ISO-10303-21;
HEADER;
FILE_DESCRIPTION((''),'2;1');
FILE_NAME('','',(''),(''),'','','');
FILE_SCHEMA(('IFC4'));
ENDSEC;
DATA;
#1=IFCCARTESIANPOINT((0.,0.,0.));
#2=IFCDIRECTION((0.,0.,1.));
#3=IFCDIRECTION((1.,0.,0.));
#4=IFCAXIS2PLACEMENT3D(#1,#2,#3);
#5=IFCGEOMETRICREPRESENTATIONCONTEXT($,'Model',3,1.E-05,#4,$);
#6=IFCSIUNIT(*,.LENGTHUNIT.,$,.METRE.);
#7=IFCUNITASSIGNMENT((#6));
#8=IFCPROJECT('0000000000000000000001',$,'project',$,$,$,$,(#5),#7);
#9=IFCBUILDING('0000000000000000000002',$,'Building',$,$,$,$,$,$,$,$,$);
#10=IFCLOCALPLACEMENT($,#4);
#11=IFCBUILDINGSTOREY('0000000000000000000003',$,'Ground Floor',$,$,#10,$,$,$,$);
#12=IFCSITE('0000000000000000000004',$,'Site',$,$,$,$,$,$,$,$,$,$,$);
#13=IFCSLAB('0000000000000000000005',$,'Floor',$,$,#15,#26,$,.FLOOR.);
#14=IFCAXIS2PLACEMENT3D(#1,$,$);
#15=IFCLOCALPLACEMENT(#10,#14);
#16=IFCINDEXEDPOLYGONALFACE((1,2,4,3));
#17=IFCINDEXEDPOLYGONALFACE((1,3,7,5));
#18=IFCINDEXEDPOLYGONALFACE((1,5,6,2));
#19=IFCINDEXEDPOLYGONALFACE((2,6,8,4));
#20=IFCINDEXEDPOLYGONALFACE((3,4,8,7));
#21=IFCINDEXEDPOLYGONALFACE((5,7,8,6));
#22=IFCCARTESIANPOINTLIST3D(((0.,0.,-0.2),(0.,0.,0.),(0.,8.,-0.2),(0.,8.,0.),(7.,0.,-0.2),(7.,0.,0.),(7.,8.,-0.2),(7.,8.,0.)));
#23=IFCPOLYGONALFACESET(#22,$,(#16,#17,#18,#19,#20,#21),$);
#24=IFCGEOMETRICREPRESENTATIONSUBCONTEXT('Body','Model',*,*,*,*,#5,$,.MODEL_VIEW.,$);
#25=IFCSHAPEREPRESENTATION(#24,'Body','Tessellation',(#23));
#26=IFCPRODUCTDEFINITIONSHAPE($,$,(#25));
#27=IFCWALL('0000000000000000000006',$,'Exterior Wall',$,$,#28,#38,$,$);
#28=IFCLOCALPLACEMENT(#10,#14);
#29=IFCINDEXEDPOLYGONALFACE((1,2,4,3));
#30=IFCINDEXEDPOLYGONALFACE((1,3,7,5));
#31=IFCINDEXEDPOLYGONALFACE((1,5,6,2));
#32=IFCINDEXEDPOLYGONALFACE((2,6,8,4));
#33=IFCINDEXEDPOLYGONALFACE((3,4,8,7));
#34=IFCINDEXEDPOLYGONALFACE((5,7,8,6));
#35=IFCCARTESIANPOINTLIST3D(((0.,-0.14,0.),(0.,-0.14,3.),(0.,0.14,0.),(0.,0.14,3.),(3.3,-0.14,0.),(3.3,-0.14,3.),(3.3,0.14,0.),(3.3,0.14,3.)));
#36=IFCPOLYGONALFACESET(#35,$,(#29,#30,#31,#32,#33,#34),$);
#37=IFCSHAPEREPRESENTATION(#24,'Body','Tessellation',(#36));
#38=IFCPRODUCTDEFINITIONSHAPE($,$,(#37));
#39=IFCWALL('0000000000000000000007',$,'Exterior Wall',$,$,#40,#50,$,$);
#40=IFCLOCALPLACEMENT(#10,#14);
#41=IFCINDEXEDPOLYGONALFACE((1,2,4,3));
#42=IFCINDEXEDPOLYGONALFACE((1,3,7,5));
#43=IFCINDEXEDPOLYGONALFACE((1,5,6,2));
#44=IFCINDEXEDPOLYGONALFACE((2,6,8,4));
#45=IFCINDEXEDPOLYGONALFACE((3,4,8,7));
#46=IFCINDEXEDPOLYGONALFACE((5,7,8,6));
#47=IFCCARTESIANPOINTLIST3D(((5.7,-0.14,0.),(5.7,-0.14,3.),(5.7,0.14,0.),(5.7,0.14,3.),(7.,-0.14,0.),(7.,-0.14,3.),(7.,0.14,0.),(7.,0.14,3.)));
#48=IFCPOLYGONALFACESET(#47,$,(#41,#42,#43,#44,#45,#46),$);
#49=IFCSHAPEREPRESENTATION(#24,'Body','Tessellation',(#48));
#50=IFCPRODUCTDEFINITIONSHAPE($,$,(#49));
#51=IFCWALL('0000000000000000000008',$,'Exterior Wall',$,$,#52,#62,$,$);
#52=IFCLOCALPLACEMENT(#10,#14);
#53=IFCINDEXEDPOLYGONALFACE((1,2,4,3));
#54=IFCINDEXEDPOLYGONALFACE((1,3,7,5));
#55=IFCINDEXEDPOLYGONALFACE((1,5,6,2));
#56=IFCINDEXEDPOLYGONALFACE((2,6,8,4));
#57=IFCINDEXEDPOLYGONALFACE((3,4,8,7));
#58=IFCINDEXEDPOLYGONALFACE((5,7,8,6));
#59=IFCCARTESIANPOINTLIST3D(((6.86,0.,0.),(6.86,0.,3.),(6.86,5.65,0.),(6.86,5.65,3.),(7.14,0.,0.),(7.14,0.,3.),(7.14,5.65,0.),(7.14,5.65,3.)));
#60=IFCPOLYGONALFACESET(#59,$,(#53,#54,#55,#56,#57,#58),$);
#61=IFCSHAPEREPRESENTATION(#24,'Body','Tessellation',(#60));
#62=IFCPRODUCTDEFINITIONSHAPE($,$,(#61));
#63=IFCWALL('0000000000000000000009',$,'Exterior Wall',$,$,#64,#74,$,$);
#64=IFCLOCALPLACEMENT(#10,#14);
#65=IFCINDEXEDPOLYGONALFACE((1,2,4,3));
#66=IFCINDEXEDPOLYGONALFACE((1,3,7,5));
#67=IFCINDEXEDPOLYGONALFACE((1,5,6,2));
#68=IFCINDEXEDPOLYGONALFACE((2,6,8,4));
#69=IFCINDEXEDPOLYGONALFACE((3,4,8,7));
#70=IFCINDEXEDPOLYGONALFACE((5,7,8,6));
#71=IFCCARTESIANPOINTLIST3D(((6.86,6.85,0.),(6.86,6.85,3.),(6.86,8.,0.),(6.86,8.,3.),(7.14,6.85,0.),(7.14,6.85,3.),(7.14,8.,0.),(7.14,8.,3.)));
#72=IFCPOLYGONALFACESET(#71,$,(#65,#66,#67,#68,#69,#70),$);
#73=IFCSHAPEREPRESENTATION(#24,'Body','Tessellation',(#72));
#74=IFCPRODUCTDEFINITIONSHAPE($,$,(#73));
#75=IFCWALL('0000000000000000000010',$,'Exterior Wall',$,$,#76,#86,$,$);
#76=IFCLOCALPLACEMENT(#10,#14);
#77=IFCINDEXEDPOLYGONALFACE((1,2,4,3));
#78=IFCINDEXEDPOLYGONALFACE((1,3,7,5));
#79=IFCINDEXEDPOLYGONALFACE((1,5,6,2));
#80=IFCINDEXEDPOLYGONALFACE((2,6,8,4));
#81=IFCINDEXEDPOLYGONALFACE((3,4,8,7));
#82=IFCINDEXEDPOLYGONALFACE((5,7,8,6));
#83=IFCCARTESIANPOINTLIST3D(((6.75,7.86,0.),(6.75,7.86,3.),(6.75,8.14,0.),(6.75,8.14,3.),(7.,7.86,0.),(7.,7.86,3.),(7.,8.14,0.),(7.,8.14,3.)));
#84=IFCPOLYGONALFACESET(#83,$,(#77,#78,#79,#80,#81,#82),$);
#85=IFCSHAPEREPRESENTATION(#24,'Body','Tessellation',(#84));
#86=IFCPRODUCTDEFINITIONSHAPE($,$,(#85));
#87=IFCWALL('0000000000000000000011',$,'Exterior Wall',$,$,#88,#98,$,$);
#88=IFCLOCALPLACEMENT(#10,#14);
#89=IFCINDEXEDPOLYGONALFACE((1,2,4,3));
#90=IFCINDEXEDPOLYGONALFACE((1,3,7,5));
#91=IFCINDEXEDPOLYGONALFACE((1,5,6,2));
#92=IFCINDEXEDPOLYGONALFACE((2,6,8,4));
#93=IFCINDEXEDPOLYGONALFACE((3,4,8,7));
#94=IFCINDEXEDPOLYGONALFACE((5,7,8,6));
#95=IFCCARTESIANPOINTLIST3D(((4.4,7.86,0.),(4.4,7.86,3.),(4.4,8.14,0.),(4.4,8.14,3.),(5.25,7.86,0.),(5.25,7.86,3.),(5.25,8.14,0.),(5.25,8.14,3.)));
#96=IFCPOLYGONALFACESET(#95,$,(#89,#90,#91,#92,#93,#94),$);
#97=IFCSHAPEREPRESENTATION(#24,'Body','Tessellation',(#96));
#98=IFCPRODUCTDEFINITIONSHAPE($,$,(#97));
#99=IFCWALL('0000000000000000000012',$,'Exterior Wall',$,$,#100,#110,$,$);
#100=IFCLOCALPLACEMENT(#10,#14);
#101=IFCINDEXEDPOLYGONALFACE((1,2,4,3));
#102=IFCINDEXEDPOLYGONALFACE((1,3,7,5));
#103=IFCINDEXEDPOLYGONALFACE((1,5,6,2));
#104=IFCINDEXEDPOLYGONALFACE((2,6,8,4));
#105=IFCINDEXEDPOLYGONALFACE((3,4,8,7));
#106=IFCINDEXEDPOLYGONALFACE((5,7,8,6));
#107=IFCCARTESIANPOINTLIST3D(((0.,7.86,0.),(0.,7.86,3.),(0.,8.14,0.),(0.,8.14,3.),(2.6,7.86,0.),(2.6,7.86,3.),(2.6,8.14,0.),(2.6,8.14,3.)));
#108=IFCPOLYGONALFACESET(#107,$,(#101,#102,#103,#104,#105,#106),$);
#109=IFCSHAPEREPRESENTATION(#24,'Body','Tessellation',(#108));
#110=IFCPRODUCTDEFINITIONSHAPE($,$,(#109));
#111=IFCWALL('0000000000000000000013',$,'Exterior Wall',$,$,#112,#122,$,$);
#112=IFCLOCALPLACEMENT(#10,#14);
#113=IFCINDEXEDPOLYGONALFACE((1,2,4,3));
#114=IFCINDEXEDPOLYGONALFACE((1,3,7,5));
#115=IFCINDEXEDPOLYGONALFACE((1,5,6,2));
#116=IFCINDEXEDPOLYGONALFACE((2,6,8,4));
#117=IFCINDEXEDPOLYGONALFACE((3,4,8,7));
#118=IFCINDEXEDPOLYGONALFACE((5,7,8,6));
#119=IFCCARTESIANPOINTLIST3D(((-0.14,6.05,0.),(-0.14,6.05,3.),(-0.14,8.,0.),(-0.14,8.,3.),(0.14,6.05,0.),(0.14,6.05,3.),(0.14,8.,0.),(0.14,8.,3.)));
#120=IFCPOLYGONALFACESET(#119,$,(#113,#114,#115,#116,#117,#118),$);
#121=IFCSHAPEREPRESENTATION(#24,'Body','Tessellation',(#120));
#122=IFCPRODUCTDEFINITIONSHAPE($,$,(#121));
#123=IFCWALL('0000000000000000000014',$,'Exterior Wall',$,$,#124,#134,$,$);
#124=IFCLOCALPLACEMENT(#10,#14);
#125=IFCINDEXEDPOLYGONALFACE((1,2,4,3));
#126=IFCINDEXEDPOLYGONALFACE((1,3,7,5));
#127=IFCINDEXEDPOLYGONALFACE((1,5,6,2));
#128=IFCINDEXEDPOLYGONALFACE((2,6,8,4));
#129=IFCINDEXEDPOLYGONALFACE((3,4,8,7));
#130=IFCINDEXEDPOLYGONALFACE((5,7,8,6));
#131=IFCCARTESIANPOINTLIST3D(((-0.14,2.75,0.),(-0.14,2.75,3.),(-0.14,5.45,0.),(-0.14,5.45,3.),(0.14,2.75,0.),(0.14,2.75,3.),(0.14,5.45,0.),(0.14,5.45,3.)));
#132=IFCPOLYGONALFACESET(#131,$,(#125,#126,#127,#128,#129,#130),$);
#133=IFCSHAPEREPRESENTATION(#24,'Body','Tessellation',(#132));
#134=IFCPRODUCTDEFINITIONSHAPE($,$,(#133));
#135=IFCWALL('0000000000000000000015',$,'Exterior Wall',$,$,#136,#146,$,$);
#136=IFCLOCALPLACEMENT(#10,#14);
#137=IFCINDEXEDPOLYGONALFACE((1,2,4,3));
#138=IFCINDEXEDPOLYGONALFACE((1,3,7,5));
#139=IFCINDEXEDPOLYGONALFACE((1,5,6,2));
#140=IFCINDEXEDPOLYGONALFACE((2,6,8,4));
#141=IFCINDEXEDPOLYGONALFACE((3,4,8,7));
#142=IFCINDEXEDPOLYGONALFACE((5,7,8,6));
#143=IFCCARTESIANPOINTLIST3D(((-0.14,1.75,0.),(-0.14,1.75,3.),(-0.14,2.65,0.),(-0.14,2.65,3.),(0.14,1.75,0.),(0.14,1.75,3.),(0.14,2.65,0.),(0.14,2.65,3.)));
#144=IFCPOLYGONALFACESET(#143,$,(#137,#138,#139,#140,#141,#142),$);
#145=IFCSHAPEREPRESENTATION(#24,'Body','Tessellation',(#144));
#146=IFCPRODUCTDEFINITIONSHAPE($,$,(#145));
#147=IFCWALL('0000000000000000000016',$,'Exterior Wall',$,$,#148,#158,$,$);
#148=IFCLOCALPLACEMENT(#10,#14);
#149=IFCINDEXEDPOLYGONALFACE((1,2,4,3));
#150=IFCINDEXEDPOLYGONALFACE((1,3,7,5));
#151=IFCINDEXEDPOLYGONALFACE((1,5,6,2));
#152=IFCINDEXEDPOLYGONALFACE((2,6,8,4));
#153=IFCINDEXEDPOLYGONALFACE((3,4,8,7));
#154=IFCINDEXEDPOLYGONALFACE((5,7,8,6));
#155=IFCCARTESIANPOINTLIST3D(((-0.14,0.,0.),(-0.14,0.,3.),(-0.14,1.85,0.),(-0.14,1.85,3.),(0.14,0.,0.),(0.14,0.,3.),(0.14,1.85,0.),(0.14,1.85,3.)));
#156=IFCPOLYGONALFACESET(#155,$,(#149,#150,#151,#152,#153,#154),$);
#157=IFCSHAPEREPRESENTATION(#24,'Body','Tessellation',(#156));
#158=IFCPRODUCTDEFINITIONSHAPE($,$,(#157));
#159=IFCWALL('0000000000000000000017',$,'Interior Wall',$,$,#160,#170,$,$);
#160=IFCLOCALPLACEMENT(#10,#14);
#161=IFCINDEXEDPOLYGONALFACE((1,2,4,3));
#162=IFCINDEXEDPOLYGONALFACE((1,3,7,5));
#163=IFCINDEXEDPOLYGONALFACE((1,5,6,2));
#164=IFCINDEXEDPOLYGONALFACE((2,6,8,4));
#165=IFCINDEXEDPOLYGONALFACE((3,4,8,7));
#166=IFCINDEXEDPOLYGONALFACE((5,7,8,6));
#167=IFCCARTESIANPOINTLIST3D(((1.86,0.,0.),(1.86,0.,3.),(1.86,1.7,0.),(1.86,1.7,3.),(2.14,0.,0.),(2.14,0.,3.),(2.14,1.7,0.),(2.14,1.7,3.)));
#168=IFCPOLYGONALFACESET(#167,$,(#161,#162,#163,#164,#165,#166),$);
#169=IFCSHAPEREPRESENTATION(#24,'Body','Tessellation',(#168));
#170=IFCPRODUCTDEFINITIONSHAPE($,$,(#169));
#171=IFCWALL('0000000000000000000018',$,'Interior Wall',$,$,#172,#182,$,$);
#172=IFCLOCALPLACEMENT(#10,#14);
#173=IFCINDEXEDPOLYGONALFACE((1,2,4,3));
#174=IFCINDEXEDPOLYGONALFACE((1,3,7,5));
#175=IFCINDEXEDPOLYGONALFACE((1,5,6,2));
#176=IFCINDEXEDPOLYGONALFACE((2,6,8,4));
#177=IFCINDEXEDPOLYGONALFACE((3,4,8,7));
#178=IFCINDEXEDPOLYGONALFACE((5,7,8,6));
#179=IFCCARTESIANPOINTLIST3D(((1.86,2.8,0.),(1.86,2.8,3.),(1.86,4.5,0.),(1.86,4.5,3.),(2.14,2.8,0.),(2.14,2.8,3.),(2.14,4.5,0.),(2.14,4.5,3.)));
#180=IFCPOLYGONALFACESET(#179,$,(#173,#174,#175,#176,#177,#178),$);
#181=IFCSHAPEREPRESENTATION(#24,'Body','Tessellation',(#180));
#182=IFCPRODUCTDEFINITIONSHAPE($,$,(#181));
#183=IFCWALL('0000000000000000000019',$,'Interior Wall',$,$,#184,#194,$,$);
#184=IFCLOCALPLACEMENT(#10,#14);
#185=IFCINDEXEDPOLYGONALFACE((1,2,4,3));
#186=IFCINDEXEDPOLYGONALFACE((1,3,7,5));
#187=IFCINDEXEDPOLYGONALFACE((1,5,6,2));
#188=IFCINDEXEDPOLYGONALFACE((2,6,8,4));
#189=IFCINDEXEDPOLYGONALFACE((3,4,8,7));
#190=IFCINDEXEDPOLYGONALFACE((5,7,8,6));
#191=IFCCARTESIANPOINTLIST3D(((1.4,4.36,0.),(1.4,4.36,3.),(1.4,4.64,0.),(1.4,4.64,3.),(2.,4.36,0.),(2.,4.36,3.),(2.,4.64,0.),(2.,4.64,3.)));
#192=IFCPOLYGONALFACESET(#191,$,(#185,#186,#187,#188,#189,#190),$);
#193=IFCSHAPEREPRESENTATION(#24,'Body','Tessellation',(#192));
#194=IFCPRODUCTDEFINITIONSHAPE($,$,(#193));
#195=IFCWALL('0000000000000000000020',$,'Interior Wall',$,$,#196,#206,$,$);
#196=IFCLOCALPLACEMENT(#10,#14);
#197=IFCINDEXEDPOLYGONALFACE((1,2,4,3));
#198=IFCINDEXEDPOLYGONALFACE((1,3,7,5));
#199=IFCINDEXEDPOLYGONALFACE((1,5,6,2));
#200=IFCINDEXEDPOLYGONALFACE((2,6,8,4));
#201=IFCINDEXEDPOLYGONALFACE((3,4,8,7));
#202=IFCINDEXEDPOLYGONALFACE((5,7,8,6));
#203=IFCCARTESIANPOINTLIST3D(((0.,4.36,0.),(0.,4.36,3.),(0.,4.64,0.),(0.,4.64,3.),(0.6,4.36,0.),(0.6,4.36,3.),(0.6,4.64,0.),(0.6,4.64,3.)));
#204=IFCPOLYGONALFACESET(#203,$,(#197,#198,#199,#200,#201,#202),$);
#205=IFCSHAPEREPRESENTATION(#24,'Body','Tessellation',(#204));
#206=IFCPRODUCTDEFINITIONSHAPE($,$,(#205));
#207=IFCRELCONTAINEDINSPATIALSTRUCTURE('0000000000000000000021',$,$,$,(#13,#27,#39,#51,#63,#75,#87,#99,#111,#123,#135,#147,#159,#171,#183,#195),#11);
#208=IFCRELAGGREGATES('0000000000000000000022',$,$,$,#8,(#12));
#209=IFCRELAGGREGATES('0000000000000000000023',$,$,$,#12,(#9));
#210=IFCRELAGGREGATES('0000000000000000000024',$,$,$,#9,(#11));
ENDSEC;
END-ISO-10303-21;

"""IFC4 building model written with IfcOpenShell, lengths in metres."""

from ifc_helpers import new_model, si_unit, frame, origin_with_axes, place, context, subcontext, project, spatial, indexed_curve, outline, extrude, element, save


model = new_model("IFC4")

# Units and contexts
model_context = context("Model", 3, precision=1e-05, world=origin_with_axes())
body_context = subcontext(model_context, "Body", "Model", "MODEL_VIEW")
ifc_project = project(units=[si_unit("LENGTHUNIT", "METRE")], contexts=[model_context])

# Site, building, storey
site = spatial("IfcSite", under=ifc_project, Name="Site")
building = spatial("IfcBuilding", under=site, Name="Building")
storey_placement = place(None, origin_with_axes())
storey = spatial("IfcBuildingStorey", under=building, at=storey_placement, Name="Ground Floor")

# Slab
slab_placement = place(storey_placement, frame((0.0, 0.0, -0.2), z_axis=(0.0, 0.0, 1.0), x_axis=(1.0, 0.0, 0.0)))
element("IfcSlab", 1, at=slab_placement, inside=storey, Name="Floor", PredefinedType="FLOOR", context=body_context, shape_type="SweptSolid", body=[
    extrude(outline(indexed_curve([(0.0, 0.0), (7.0, 0.0), (7.0, 8.0), (0.0, 8.0)])), None, (0.0, 0.0, 1.0), 0.2),
])

# Walls
wall_1_placement = place(storey_placement, origin_with_axes())
element("IfcWall", 2, at=wall_1_placement, inside=storey, Name="Exterior Wall", context=body_context, shape_type="SweptSolid", body=[
    extrude(outline(indexed_curve([(0.0, 0.0), (0.0, 0.28), (3.3, 0.28), (3.3, 0.0), (0.0, 0.0)], self_intersect=False)), frame((0.0, -0.14, 0.0), z_axis=(0.0, 0.0, 1.0), x_axis=(1.0, 0.0, 0.0)), (0.0, 0.0, 1.0), 3.0),
])
wall_2_placement = place(storey_placement, frame((5.7, 0.0, 0.0), z_axis=(0.0, 0.0, 1.0), x_axis=(1.0, 0.0, 0.0)))
element("IfcWall", 3, at=wall_2_placement, inside=storey, Name="Exterior Wall", context=body_context, shape_type="SweptSolid", body=[
    extrude(outline(indexed_curve([(0.0, 0.0), (0.0, 0.28), (1.3, 0.28), (1.3, 0.0), (0.0, 0.0)], self_intersect=False)), frame((0.0, -0.14, 0.0), z_axis=(0.0, 0.0, 1.0), x_axis=(1.0, 0.0, 0.0)), (0.0, 0.0, 1.0), 3.0),
])
wall_3_placement = place(storey_placement, frame((7.0, 0.0, 0.0), z_axis=(0.0, 0.0, 1.0), x_axis=(0.0, 1.0, 0.0)))
element("IfcWall", 4, at=wall_3_placement, inside=storey, Name="Exterior Wall", context=body_context, shape_type="SweptSolid", body=[
    extrude(outline(indexed_curve([(0.0, 0.0), (0.0, 0.28), (5.65, 0.28), (5.65, 0.0), (0.0, 0.0)], self_intersect=False)), frame((0.0, -0.14, 0.0), z_axis=(0.0, 0.0, 1.0), x_axis=(1.0, 0.0, 0.0)), (0.0, 0.0, 1.0), 3.0),
])
wall_4_placement = place(storey_placement, frame((7.0, 6.85, 0.0), z_axis=(0.0, 0.0, 1.0), x_axis=(0.0, 1.0, 0.0)))
element("IfcWall", 5, at=wall_4_placement, inside=storey, Name="Exterior Wall", context=body_context, shape_type="SweptSolid", body=[
    extrude(outline(indexed_curve([(0.0, 0.0), (0.0, 0.28), (1.15, 0.28), (1.15, 0.0), (0.0, 0.0)], self_intersect=False)), frame((0.0, -0.14, 0.0), z_axis=(0.0, 0.0, 1.0), x_axis=(1.0, 0.0, 0.0)), (0.0, 0.0, 1.0), 3.0),
])
wall_5_placement = place(storey_placement, frame((7.0, 8.0, 0.0), z_axis=(0.0, 0.0, 1.0), x_axis=(-1.0, 0.0, 0.0)))
element("IfcWall", 6, at=wall_5_placement, inside=storey, Name="Exterior Wall", context=body_context, shape_type="SweptSolid", body=[
    extrude(outline(indexed_curve([(0.0, 0.0), (0.0, 0.28), (0.25, 0.28), (0.25, 0.0), (0.0, 0.0)], self_intersect=False)), frame((0.0, -0.14, 0.0), z_axis=(0.0, 0.0, 1.0), x_axis=(1.0, 0.0, 0.0)), (0.0, 0.0, 1.0), 3.0),
])
wall_6_placement = place(storey_placement, frame((5.25, 8.0, 0.0), z_axis=(0.0, 0.0, 1.0), x_axis=(-1.0, 0.0, 0.0)))
element("IfcWall", 7, at=wall_6_placement, inside=storey, Name="Exterior Wall", context=body_context, shape_type="SweptSolid", body=[
    extrude(outline(indexed_curve([(0.0, 0.0), (0.0, 0.28), (0.85, 0.28), (0.85, 0.0), (0.0, 0.0)], self_intersect=False)), frame((0.0, -0.14, 0.0), z_axis=(0.0, 0.0, 1.0), x_axis=(1.0, 0.0, 0.0)), (0.0, 0.0, 1.0), 3.0),
])
wall_7_placement = place(storey_placement, frame((2.6, 8.0, 0.0), z_axis=(0.0, 0.0, 1.0), x_axis=(-1.0, 0.0, 0.0)))
element("IfcWall", 8, at=wall_7_placement, inside=storey, Name="Exterior Wall", context=body_context, shape_type="SweptSolid", body=[
    extrude(outline(indexed_curve([(0.0, 0.0), (0.0, 0.28), (2.6, 0.28), (2.6, 0.0), (0.0, 0.0)], self_intersect=False)), frame((0.0, -0.14, 0.0), z_axis=(0.0, 0.0, 1.0), x_axis=(1.0, 0.0, 0.0)), (0.0, 0.0, 1.0), 3.0),
])
wall_8_placement = place(storey_placement, frame((0.0, 8.0, 0.0), z_axis=(0.0, 0.0, 1.0), x_axis=(0.0, -1.0, 0.0)))
element("IfcWall", 9, at=wall_8_placement, inside=storey, Name="Exterior Wall", context=body_context, shape_type="SweptSolid", body=[
    extrude(outline(indexed_curve([(0.0, 0.0), (0.0, 0.28), (1.95, 0.28), (1.95, 0.0), (0.0, 0.0)], self_intersect=False)), frame((0.0, -0.14, 0.0), z_axis=(0.0, 0.0, 1.0), x_axis=(1.0, 0.0, 0.0)), (0.0, 0.0, 1.0), 3.0),
])
wall_9_placement = place(storey_placement, frame((0.0, 5.45, 0.0), z_axis=(0.0, 0.0, 1.0), x_axis=(0.0, -1.0, 0.0)))
element("IfcWall", 10, at=wall_9_placement, inside=storey, Name="Exterior Wall", context=body_context, shape_type="SweptSolid", body=[
    extrude(outline(indexed_curve([(0.0, 0.0), (0.0, 0.28), (2.7, 0.28), (2.7, 0.0), (0.0, 0.0)], self_intersect=False)), frame((0.0, -0.14, 0.0), z_axis=(0.0, 0.0, 1.0), x_axis=(1.0, 0.0, 0.0)), (0.0, 0.0, 1.0), 3.0),
])
wall_10_placement = place(storey_placement, frame((0.0, 1.75, 0.0), z_axis=(0.0, 0.0, 1.0), x_axis=(0.0, 1.0, 0.0)))
element("IfcWall", 11, at=wall_10_placement, inside=storey, Name="Exterior Wall", context=body_context, shape_type="SweptSolid", body=[
    extrude(outline(indexed_curve([(0.0, 0.0), (0.0, 0.28), (0.9, 0.28), (0.9, 0.0), (0.0, 0.0)], self_intersect=False)), frame((0.0, -0.14, 0.0), z_axis=(0.0, 0.0, 1.0), x_axis=(1.0, 0.0, 0.0)), (0.0, 0.0, 1.0), 3.0),
])
wall_11_placement = place(storey_placement, frame((0.0, 1.85, 0.0), z_axis=(0.0, 0.0, 1.0), x_axis=(0.0, -1.0, 0.0)))
element("IfcWall", 12, at=wall_11_placement, inside=storey, Name="Exterior Wall", context=body_context, shape_type="SweptSolid", body=[
    extrude(outline(indexed_curve([(0.0, 0.0), (0.0, 0.28), (1.85, 0.28), (1.85, 0.0), (0.0, 0.0)], self_intersect=False)), frame((0.0, -0.14, 0.0), z_axis=(0.0, 0.0, 1.0), x_axis=(1.0, 0.0, 0.0)), (0.0, 0.0, 1.0), 3.0),
])
wall_12_placement = place(storey_placement, frame((2.0, 0.0, 0.0), z_axis=(0.0, 0.0, 1.0), x_axis=(0.0, 1.0, 0.0)))
element("IfcWall", 13, at=wall_12_placement, inside=storey, Name="Interior Wall", context=body_context, shape_type="SweptSolid", body=[
    extrude(outline(indexed_curve([(0.0, 0.0), (0.0, 0.28), (1.7, 0.28), (1.7, 0.0), (0.0, 0.0)], self_intersect=False)), frame((0.0, -0.14, 0.0), z_axis=(0.0, 0.0, 1.0), x_axis=(1.0, 0.0, 0.0)), (0.0, 0.0, 1.0), 3.0),
])
wall_13_placement = place(storey_placement, frame((2.0, 2.8, 0.0), z_axis=(0.0, 0.0, 1.0), x_axis=(0.0, 1.0, 0.0)))
element("IfcWall", 14, at=wall_13_placement, inside=storey, Name="Interior Wall", context=body_context, shape_type="SweptSolid", body=[
    extrude(outline(indexed_curve([(0.0, 0.0), (0.0, 0.28), (1.7, 0.28), (1.7, 0.0), (0.0, 0.0)], self_intersect=False)), frame((0.0, -0.14, 0.0), z_axis=(0.0, 0.0, 1.0), x_axis=(1.0, 0.0, 0.0)), (0.0, 0.0, 1.0), 3.0),
])
for number, where, z_axis, x_axis, name in (
    (15, (2.0, 4.5, 0.0), (0.0, 0.0, 1.0), (-1.0, 0.0, 0.0), "Interior Wall"),
    (16, (0.6, 4.5, 0.0), (0.0, 0.0, 1.0), (-1.0, 0.0, 0.0), "Interior Wall"),
):
    element("IfcWall", number, at=place(storey_placement, frame(where, z_axis=z_axis, x_axis=x_axis)), inside=storey, Name=name, context=body_context, shape_type="SweptSolid", body=[
        extrude(outline(indexed_curve([(0.0, 0.0), (0.0, 0.28), (0.6, 0.28), (0.6, 0.0), (0.0, 0.0)], self_intersect=False)), frame((0.0, -0.14, 0.0), z_axis=(0.0, 0.0, 1.0), x_axis=(1.0, 0.0, 0.0)), (0.0, 0.0, 1.0), 3.0),
    ])

save(model, "model.ifc")
